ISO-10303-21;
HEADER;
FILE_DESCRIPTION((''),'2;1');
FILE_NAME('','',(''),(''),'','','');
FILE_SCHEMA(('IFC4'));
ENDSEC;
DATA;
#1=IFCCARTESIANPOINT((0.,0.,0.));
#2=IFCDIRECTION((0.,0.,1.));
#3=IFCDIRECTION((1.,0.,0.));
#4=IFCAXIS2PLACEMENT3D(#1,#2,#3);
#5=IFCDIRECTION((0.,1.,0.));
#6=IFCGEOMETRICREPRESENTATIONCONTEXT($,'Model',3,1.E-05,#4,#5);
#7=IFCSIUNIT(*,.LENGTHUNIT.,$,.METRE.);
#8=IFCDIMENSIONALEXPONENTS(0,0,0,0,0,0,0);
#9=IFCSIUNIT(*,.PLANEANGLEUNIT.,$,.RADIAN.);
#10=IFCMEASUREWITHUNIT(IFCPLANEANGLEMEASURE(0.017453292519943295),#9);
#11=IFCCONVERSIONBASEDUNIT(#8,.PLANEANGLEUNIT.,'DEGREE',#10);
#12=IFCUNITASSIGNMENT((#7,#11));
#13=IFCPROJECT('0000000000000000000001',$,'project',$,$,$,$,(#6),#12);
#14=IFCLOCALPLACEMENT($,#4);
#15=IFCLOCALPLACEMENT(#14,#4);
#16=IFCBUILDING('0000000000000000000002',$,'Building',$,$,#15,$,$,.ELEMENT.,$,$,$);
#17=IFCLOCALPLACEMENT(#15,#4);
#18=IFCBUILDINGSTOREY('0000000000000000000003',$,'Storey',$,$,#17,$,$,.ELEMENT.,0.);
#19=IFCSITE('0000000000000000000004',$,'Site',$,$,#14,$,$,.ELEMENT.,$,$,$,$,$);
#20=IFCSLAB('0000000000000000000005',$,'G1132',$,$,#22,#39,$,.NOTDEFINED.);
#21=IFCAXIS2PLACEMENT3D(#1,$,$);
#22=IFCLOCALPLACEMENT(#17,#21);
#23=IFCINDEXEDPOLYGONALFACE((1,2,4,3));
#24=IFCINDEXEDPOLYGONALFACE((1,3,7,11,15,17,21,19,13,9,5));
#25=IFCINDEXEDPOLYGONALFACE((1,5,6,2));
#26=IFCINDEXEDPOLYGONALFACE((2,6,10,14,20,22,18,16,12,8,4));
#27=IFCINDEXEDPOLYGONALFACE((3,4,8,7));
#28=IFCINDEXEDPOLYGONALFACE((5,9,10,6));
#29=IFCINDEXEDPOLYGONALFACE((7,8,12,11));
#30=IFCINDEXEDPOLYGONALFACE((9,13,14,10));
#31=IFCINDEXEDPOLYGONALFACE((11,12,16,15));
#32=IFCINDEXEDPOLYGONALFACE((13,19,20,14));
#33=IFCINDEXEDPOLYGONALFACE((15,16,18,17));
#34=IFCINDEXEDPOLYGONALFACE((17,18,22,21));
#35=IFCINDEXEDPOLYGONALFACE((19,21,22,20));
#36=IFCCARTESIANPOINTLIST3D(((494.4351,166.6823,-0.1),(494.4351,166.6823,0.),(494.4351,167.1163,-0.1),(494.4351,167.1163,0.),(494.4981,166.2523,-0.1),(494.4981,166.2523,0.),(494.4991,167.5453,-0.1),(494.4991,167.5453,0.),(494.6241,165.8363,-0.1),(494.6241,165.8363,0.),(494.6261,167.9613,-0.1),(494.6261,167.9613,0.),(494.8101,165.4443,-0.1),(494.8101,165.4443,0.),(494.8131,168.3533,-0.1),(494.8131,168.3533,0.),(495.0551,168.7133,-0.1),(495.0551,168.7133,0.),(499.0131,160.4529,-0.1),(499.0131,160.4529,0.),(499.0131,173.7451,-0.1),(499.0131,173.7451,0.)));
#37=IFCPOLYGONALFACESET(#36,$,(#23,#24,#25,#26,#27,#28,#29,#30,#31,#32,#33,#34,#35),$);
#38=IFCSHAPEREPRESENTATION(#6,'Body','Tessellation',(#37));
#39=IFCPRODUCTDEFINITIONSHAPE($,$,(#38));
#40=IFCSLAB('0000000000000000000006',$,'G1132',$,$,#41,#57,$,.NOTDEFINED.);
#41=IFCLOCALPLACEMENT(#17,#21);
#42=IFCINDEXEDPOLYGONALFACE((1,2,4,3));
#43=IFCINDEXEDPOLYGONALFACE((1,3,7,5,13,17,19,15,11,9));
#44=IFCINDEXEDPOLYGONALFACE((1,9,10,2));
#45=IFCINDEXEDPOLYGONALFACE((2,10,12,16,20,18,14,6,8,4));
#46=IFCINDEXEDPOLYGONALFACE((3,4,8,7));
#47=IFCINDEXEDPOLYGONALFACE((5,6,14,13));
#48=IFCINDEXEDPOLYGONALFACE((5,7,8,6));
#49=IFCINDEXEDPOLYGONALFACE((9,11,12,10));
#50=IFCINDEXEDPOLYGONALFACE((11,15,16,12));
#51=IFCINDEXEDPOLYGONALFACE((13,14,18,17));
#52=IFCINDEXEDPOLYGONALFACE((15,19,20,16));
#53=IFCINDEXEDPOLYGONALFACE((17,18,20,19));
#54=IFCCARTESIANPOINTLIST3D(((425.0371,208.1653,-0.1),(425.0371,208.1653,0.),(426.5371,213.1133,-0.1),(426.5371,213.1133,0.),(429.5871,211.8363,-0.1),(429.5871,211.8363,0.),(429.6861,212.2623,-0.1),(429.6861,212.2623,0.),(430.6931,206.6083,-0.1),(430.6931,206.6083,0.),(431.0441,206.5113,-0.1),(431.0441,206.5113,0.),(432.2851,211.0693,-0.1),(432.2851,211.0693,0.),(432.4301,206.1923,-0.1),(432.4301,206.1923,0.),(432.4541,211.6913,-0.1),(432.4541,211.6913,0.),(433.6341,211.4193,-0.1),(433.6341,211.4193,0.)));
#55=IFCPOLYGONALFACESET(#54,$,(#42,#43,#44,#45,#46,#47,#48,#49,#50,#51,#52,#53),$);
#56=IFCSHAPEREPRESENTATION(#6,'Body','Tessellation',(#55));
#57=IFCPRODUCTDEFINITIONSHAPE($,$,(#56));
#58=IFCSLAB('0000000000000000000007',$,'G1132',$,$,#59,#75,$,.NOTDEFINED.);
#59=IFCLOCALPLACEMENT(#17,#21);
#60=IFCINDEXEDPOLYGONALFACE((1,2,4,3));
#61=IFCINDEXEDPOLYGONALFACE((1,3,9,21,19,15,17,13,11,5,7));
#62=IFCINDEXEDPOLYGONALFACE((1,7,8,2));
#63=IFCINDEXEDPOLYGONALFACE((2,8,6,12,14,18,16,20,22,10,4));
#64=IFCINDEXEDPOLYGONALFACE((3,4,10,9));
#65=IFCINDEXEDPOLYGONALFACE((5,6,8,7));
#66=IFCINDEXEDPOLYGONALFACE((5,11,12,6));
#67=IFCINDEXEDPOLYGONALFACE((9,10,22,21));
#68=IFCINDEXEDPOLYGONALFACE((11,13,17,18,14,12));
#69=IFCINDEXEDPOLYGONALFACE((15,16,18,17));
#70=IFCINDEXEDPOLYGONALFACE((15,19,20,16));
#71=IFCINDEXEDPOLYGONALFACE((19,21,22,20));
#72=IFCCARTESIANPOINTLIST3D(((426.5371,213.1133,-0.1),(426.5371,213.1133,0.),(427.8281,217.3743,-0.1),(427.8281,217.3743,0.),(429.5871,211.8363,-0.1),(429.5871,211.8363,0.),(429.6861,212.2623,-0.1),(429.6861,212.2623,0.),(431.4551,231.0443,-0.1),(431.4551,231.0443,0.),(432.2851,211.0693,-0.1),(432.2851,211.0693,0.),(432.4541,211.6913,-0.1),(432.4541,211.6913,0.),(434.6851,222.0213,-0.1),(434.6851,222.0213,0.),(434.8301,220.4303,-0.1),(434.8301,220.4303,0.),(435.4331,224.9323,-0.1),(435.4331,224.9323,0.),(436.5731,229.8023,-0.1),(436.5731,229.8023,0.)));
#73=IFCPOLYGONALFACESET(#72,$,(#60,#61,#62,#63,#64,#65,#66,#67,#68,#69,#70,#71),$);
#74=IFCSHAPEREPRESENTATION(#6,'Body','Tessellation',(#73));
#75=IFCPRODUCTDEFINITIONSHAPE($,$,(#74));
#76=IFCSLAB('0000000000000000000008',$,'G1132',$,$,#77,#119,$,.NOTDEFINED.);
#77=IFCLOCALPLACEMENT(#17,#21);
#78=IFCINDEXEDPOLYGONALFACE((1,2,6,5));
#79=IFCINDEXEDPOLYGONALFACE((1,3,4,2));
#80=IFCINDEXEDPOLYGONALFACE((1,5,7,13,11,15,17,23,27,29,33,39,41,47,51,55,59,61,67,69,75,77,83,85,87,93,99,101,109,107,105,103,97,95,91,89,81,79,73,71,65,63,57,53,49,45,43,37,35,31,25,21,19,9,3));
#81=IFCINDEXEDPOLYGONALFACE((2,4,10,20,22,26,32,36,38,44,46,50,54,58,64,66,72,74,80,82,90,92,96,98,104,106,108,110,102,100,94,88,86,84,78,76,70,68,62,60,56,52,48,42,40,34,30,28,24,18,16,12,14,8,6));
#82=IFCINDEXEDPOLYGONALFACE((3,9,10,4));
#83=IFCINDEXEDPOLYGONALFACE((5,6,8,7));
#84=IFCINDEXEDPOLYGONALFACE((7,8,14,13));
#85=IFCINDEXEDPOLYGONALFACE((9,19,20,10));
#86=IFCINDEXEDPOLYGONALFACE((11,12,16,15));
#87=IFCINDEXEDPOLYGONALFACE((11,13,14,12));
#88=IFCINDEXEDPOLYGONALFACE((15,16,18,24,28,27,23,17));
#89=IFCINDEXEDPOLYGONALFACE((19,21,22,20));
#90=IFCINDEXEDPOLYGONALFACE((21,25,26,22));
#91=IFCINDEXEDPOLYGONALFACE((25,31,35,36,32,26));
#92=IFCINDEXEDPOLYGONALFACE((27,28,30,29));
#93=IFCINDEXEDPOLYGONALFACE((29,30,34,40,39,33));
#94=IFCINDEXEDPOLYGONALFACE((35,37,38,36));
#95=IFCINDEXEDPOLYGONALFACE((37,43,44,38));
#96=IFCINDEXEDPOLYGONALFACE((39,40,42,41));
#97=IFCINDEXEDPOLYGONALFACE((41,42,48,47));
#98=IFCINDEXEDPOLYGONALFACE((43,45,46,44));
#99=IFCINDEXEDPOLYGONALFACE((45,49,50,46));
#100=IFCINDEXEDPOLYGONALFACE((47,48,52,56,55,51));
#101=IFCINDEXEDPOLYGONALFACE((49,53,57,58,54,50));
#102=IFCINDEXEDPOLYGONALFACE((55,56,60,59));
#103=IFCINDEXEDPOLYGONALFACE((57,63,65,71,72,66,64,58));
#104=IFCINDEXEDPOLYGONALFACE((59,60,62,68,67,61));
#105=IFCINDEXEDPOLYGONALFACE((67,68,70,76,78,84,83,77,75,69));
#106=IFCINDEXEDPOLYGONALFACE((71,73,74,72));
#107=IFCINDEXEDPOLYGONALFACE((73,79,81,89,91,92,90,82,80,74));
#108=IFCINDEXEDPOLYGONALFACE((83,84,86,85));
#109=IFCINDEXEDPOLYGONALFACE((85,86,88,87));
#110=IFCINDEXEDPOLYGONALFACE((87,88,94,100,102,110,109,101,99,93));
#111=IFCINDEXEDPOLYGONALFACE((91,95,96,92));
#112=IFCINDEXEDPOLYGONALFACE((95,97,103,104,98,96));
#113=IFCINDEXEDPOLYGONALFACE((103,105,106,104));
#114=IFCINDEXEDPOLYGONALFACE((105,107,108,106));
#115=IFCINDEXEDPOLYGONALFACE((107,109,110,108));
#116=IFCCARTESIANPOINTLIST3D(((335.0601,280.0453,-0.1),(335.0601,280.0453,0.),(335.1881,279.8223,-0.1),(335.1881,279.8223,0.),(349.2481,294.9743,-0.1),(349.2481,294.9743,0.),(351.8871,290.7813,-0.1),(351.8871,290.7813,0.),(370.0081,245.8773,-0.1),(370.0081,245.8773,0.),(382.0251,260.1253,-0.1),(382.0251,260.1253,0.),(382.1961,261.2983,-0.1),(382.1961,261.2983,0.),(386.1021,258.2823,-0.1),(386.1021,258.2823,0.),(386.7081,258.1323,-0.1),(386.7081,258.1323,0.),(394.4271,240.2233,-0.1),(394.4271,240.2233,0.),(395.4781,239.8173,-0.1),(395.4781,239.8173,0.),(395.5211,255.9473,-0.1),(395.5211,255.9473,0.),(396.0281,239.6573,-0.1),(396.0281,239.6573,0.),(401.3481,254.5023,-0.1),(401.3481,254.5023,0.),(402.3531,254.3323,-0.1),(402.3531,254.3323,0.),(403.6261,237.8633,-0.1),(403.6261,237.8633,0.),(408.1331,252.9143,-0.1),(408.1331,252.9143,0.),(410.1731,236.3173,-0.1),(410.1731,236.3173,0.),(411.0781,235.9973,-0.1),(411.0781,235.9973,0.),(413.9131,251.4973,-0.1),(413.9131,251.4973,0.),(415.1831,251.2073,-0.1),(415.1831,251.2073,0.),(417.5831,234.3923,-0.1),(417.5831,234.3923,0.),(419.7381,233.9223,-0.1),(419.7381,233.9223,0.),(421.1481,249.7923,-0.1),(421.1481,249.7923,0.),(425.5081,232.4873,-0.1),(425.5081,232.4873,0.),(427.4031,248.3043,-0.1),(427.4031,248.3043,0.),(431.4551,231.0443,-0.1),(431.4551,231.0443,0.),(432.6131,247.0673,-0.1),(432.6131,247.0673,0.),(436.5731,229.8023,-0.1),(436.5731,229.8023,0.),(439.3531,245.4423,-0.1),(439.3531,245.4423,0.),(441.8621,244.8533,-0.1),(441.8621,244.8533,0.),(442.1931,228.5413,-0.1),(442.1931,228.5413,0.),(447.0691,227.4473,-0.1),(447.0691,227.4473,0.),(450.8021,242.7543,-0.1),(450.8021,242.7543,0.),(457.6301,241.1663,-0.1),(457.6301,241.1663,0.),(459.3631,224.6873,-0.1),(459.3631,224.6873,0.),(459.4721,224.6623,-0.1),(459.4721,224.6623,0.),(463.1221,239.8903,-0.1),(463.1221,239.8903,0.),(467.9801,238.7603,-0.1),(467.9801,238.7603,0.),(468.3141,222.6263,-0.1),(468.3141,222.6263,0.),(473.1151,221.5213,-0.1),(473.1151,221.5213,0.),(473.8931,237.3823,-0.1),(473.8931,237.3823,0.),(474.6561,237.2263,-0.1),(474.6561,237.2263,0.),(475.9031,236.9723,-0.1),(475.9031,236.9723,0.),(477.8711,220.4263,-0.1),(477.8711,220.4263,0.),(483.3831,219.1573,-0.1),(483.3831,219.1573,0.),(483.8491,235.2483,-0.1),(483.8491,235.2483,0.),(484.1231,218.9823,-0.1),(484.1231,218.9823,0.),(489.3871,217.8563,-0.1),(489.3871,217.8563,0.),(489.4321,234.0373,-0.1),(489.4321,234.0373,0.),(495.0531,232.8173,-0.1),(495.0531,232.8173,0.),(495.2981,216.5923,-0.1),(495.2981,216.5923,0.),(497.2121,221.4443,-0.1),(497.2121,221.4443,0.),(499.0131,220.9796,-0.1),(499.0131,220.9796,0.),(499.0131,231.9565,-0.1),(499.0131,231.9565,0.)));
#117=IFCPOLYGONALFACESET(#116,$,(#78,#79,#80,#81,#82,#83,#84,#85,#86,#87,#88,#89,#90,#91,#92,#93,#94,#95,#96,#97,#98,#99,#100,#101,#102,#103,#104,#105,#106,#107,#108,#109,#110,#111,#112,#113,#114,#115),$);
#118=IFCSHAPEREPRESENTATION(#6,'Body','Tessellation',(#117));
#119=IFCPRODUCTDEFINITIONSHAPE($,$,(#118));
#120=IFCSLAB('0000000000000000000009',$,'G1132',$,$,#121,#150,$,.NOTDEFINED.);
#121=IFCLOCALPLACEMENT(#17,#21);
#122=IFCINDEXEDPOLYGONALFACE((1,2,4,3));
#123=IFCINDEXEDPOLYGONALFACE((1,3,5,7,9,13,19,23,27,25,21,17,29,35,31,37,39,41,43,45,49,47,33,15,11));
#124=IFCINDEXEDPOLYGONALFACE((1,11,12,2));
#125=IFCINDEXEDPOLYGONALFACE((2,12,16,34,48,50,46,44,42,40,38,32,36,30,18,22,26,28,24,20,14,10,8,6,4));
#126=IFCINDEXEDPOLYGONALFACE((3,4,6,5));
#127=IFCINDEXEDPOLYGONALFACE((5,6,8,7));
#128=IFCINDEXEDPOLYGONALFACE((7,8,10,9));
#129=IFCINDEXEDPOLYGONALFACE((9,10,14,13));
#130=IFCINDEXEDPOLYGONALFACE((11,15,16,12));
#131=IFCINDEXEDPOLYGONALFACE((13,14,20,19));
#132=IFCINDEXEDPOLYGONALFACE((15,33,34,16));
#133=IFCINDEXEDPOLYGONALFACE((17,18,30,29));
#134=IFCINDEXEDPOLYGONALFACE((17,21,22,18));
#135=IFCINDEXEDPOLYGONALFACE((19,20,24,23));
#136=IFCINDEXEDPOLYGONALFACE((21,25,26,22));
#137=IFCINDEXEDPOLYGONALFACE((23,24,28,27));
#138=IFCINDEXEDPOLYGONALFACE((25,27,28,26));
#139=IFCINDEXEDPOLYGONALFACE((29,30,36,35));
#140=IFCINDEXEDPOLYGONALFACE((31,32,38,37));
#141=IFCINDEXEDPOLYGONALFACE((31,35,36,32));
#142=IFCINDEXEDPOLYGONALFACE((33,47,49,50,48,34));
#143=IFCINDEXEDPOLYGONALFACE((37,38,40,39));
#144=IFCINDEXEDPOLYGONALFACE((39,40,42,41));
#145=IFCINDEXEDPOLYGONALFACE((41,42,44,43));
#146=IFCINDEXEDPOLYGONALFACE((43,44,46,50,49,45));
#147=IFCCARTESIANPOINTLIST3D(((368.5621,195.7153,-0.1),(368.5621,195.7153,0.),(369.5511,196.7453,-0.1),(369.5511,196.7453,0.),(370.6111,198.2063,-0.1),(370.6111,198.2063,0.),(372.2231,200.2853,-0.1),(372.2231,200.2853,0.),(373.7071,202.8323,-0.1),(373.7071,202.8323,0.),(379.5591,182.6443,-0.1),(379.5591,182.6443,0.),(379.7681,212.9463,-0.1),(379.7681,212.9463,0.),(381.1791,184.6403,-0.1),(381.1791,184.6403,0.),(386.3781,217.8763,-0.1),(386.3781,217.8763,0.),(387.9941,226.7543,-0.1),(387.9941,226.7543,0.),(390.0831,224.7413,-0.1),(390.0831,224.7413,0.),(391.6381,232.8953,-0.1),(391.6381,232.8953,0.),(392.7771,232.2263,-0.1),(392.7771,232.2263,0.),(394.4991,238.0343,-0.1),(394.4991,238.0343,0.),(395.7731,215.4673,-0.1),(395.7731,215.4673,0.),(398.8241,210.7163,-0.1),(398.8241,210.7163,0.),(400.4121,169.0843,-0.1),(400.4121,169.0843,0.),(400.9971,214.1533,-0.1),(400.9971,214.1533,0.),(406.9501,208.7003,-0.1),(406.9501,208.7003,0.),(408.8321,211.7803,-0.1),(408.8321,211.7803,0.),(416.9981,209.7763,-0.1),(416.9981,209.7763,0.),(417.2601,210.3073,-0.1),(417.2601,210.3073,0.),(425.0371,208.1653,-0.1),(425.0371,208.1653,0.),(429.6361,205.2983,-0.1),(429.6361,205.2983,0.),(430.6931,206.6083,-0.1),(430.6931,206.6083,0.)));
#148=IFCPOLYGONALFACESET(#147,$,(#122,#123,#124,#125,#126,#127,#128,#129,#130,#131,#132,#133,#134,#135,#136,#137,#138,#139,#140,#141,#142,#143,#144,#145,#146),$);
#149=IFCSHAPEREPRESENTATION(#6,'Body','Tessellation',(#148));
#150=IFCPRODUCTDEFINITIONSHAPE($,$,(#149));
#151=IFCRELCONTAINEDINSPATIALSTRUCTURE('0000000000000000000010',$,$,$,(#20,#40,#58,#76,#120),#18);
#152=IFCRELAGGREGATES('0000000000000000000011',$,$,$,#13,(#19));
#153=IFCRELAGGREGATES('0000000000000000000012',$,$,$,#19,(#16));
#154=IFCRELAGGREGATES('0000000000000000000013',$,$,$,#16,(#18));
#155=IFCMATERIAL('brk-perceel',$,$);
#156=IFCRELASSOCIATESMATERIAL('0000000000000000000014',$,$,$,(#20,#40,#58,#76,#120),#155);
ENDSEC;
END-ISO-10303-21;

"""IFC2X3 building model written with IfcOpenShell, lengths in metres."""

from ifc_helpers import new_model, entity, si_unit, converted_unit, direction, frame, origin_with_axes, place, context, project, spatial, polyline, outline, extrude, material, element, save


model = new_model("IFC2X3")

# Units and contexts
model_context = context("Model", 3, precision=1e-05, world=origin_with_axes(), true_north=direction((0.0, 1.0, 0.0)))
ifc_project = project(units=[si_unit("LENGTHUNIT", "METRE"), converted_unit("PLANEANGLEUNIT", "DEGREE", entity("IfcPlaneAngleMeasure", 0.017453292519943295), si_unit("PLANEANGLEUNIT", "RADIAN"), dimensions=[0, 0, 0, 0, 0, 0, 0])], contexts=[model_context])

# Site, building, storey
site_placement = place(None, origin_with_axes())
site = spatial("IfcSite", under=ifc_project, at=site_placement, Name="Site", CompositionType="ELEMENT")
building_placement = place(site_placement, origin_with_axes())
building = spatial("IfcBuilding", under=site, at=building_placement, Name="Building", CompositionType="ELEMENT")
storey_placement = place(building_placement, origin_with_axes())
storey = spatial("IfcBuildingStorey", under=building, at=storey_placement, Name="Storey", CompositionType="ELEMENT", Elevation=0.0)

# Slabs
ifc_material = material(Name="brk-perceel")
slab_1_placement = place(storey_placement, frame((0.0, 0.0, -0.1), z_axis=(0.0, 0.0, 1.0), x_axis=(1.0, 0.0, 0.0)))
element("IfcSlab", 1, at=slab_1_placement, inside=storey, material=ifc_material, Name="G1132", PredefinedType="NOTDEFINED", context=model_context, shape_type="SweptSolid", body=[
    extrude(outline(polyline([(494.8101, 165.4443), (494.6241, 165.8363), (494.4981, 166.2523), (494.4351, 166.6823), (494.4351, 167.1163), (494.4991, 167.5453), (494.6261, 167.9613), (494.8131, 168.3533), (495.0551, 168.7133), (499.0131, 173.7451), (499.0131, 160.4529), (494.8101, 165.4443)])), origin_with_axes(), (0.0, 0.0, 1.0), 0.1),
])
slab_2_placement = place(storey_placement, frame((0.0, 0.0, -0.1), z_axis=(0.0, 0.0, 1.0), x_axis=(1.0, 0.0, 0.0)))
element("IfcSlab", 2, at=slab_2_placement, inside=storey, material=ifc_material, Name="G1132", PredefinedType="NOTDEFINED", context=model_context, shape_type="SweptSolid", body=[
    extrude(outline(polyline([(425.0371, 208.1653), (426.5371, 213.1133), (429.6861, 212.2623), (429.5871, 211.8363), (432.2851, 211.0693), (432.4541, 211.6913), (433.6341, 211.4193), (432.4301, 206.1923), (431.0441, 206.5113), (430.6931, 206.6083), (425.0371, 208.1653)])), origin_with_axes(), (0.0, 0.0, 1.0), 0.1),
])
slab_3_placement = place(storey_placement, frame((0.0, 0.0, -0.1), z_axis=(0.0, 0.0, 1.0), x_axis=(1.0, 0.0, 0.0)))
element("IfcSlab", 3, at=slab_3_placement, inside=storey, material=ifc_material, Name="G1132", PredefinedType="NOTDEFINED", context=model_context, shape_type="SweptSolid", body=[
    extrude(outline(polyline([(432.2851, 211.0693), (429.5871, 211.8363), (429.6861, 212.2623), (426.5371, 213.1133), (427.8281, 217.3743), (431.4551, 231.0443), (436.5731, 229.8023), (435.4331, 224.9323), (434.6851, 222.0213), (434.8301, 220.4303), (432.4541, 211.6913), (432.2851, 211.0693)])), origin_with_axes(), (0.0, 0.0, 1.0), 0.1),
])
slab_4_placement = place(storey_placement, frame((0.0, 0.0, -0.1), z_axis=(0.0, 0.0, 1.0), x_axis=(1.0, 0.0, 0.0)))
element("IfcSlab", 4, at=slab_4_placement, inside=storey, material=ifc_material, Name="G1132", PredefinedType="NOTDEFINED", context=model_context, shape_type="SweptSolid", body=[
    extrude(outline(polyline([(497.2121, 221.4443), (495.2981, 216.5923), (489.3871, 217.8563), (484.1231, 218.9823), (483.3831, 219.1573), (477.8711, 220.4263), (473.1151, 221.5213), (468.3141, 222.6263), (459.4721, 224.6623), (459.3631, 224.6873), (447.0691, 227.4473), (442.1931, 228.5413), (436.5731, 229.8023), (431.4551, 231.0443), (425.5081, 232.4873), (419.7381, 233.9223), (417.5831, 234.3923), (411.0781, 235.9973), (410.1731, 236.3173), (403.6261, 237.8633), (396.0281, 239.6573), (395.4781, 239.8173), (394.4271, 240.2233), (370.0081, 245.8773), (335.1881, 279.8223), (335.0601, 280.0453), (349.2481, 294.9743), (351.8871, 290.7813), (382.1961, 261.2983), (382.0251, 260.1253), (386.1021, 258.2823), (386.7081, 258.1323), (395.5211, 255.9473), (401.3481, 254.5023), (402.3531, 254.3323), (408.1331, 252.9143), (413.9131, 251.4973), (415.1831, 251.2073), (421.1481, 249.7923), (427.4031, 248.3043), (432.6131, 247.0673), (439.3531, 245.4423), (441.8621, 244.8533), (450.8021, 242.7543), (457.6301, 241.1663), (463.1221, 239.8903), (467.9801, 238.7603), (473.8931, 237.3823), (474.6561, 237.2263), (475.9031, 236.9723), (483.8491, 235.2483), (489.4321, 234.0373), (495.0531, 232.8173), (499.0131, 231.9565), (499.0131, 220.9796), (497.2121, 221.4443)])), origin_with_axes(), (0.0, 0.0, 1.0), 0.1),
])
slab_5_placement = place(storey_placement, frame((0.0, 0.0, -0.1), z_axis=(0.0, 0.0, 1.0), x_axis=(1.0, 0.0, 0.0)))
element("IfcSlab", 5, at=slab_5_placement, inside=storey, material=ifc_material, Name="G1132", PredefinedType="NOTDEFINED", context=model_context, shape_type="SweptSolid", body=[
    extrude(outline(polyline([(400.4121, 169.0843), (381.1791, 184.6403), (379.5591, 182.6443), (368.5621, 195.7153), (369.5511, 196.7453), (370.6111, 198.2063), (372.2231, 200.2853), (373.7071, 202.8323), (379.7681, 212.9463), (387.9941, 226.7543), (391.6381, 232.8953), (394.4991, 238.0343), (392.7771, 232.2263), (390.0831, 224.7413), (386.3781, 217.8763), (395.7731, 215.4673), (400.9971, 214.1533), (398.8241, 210.7163), (406.9501, 208.7003), (408.8321, 211.7803), (416.9981, 209.7763), (417.2601, 210.3073), (425.0371, 208.1653), (430.6931, 206.6083), (429.6361, 205.2983), (400.4121, 169.0843)])), origin_with_axes(), (0.0, 0.0, 1.0), 0.1),
])

save(model, "model.ifc")
